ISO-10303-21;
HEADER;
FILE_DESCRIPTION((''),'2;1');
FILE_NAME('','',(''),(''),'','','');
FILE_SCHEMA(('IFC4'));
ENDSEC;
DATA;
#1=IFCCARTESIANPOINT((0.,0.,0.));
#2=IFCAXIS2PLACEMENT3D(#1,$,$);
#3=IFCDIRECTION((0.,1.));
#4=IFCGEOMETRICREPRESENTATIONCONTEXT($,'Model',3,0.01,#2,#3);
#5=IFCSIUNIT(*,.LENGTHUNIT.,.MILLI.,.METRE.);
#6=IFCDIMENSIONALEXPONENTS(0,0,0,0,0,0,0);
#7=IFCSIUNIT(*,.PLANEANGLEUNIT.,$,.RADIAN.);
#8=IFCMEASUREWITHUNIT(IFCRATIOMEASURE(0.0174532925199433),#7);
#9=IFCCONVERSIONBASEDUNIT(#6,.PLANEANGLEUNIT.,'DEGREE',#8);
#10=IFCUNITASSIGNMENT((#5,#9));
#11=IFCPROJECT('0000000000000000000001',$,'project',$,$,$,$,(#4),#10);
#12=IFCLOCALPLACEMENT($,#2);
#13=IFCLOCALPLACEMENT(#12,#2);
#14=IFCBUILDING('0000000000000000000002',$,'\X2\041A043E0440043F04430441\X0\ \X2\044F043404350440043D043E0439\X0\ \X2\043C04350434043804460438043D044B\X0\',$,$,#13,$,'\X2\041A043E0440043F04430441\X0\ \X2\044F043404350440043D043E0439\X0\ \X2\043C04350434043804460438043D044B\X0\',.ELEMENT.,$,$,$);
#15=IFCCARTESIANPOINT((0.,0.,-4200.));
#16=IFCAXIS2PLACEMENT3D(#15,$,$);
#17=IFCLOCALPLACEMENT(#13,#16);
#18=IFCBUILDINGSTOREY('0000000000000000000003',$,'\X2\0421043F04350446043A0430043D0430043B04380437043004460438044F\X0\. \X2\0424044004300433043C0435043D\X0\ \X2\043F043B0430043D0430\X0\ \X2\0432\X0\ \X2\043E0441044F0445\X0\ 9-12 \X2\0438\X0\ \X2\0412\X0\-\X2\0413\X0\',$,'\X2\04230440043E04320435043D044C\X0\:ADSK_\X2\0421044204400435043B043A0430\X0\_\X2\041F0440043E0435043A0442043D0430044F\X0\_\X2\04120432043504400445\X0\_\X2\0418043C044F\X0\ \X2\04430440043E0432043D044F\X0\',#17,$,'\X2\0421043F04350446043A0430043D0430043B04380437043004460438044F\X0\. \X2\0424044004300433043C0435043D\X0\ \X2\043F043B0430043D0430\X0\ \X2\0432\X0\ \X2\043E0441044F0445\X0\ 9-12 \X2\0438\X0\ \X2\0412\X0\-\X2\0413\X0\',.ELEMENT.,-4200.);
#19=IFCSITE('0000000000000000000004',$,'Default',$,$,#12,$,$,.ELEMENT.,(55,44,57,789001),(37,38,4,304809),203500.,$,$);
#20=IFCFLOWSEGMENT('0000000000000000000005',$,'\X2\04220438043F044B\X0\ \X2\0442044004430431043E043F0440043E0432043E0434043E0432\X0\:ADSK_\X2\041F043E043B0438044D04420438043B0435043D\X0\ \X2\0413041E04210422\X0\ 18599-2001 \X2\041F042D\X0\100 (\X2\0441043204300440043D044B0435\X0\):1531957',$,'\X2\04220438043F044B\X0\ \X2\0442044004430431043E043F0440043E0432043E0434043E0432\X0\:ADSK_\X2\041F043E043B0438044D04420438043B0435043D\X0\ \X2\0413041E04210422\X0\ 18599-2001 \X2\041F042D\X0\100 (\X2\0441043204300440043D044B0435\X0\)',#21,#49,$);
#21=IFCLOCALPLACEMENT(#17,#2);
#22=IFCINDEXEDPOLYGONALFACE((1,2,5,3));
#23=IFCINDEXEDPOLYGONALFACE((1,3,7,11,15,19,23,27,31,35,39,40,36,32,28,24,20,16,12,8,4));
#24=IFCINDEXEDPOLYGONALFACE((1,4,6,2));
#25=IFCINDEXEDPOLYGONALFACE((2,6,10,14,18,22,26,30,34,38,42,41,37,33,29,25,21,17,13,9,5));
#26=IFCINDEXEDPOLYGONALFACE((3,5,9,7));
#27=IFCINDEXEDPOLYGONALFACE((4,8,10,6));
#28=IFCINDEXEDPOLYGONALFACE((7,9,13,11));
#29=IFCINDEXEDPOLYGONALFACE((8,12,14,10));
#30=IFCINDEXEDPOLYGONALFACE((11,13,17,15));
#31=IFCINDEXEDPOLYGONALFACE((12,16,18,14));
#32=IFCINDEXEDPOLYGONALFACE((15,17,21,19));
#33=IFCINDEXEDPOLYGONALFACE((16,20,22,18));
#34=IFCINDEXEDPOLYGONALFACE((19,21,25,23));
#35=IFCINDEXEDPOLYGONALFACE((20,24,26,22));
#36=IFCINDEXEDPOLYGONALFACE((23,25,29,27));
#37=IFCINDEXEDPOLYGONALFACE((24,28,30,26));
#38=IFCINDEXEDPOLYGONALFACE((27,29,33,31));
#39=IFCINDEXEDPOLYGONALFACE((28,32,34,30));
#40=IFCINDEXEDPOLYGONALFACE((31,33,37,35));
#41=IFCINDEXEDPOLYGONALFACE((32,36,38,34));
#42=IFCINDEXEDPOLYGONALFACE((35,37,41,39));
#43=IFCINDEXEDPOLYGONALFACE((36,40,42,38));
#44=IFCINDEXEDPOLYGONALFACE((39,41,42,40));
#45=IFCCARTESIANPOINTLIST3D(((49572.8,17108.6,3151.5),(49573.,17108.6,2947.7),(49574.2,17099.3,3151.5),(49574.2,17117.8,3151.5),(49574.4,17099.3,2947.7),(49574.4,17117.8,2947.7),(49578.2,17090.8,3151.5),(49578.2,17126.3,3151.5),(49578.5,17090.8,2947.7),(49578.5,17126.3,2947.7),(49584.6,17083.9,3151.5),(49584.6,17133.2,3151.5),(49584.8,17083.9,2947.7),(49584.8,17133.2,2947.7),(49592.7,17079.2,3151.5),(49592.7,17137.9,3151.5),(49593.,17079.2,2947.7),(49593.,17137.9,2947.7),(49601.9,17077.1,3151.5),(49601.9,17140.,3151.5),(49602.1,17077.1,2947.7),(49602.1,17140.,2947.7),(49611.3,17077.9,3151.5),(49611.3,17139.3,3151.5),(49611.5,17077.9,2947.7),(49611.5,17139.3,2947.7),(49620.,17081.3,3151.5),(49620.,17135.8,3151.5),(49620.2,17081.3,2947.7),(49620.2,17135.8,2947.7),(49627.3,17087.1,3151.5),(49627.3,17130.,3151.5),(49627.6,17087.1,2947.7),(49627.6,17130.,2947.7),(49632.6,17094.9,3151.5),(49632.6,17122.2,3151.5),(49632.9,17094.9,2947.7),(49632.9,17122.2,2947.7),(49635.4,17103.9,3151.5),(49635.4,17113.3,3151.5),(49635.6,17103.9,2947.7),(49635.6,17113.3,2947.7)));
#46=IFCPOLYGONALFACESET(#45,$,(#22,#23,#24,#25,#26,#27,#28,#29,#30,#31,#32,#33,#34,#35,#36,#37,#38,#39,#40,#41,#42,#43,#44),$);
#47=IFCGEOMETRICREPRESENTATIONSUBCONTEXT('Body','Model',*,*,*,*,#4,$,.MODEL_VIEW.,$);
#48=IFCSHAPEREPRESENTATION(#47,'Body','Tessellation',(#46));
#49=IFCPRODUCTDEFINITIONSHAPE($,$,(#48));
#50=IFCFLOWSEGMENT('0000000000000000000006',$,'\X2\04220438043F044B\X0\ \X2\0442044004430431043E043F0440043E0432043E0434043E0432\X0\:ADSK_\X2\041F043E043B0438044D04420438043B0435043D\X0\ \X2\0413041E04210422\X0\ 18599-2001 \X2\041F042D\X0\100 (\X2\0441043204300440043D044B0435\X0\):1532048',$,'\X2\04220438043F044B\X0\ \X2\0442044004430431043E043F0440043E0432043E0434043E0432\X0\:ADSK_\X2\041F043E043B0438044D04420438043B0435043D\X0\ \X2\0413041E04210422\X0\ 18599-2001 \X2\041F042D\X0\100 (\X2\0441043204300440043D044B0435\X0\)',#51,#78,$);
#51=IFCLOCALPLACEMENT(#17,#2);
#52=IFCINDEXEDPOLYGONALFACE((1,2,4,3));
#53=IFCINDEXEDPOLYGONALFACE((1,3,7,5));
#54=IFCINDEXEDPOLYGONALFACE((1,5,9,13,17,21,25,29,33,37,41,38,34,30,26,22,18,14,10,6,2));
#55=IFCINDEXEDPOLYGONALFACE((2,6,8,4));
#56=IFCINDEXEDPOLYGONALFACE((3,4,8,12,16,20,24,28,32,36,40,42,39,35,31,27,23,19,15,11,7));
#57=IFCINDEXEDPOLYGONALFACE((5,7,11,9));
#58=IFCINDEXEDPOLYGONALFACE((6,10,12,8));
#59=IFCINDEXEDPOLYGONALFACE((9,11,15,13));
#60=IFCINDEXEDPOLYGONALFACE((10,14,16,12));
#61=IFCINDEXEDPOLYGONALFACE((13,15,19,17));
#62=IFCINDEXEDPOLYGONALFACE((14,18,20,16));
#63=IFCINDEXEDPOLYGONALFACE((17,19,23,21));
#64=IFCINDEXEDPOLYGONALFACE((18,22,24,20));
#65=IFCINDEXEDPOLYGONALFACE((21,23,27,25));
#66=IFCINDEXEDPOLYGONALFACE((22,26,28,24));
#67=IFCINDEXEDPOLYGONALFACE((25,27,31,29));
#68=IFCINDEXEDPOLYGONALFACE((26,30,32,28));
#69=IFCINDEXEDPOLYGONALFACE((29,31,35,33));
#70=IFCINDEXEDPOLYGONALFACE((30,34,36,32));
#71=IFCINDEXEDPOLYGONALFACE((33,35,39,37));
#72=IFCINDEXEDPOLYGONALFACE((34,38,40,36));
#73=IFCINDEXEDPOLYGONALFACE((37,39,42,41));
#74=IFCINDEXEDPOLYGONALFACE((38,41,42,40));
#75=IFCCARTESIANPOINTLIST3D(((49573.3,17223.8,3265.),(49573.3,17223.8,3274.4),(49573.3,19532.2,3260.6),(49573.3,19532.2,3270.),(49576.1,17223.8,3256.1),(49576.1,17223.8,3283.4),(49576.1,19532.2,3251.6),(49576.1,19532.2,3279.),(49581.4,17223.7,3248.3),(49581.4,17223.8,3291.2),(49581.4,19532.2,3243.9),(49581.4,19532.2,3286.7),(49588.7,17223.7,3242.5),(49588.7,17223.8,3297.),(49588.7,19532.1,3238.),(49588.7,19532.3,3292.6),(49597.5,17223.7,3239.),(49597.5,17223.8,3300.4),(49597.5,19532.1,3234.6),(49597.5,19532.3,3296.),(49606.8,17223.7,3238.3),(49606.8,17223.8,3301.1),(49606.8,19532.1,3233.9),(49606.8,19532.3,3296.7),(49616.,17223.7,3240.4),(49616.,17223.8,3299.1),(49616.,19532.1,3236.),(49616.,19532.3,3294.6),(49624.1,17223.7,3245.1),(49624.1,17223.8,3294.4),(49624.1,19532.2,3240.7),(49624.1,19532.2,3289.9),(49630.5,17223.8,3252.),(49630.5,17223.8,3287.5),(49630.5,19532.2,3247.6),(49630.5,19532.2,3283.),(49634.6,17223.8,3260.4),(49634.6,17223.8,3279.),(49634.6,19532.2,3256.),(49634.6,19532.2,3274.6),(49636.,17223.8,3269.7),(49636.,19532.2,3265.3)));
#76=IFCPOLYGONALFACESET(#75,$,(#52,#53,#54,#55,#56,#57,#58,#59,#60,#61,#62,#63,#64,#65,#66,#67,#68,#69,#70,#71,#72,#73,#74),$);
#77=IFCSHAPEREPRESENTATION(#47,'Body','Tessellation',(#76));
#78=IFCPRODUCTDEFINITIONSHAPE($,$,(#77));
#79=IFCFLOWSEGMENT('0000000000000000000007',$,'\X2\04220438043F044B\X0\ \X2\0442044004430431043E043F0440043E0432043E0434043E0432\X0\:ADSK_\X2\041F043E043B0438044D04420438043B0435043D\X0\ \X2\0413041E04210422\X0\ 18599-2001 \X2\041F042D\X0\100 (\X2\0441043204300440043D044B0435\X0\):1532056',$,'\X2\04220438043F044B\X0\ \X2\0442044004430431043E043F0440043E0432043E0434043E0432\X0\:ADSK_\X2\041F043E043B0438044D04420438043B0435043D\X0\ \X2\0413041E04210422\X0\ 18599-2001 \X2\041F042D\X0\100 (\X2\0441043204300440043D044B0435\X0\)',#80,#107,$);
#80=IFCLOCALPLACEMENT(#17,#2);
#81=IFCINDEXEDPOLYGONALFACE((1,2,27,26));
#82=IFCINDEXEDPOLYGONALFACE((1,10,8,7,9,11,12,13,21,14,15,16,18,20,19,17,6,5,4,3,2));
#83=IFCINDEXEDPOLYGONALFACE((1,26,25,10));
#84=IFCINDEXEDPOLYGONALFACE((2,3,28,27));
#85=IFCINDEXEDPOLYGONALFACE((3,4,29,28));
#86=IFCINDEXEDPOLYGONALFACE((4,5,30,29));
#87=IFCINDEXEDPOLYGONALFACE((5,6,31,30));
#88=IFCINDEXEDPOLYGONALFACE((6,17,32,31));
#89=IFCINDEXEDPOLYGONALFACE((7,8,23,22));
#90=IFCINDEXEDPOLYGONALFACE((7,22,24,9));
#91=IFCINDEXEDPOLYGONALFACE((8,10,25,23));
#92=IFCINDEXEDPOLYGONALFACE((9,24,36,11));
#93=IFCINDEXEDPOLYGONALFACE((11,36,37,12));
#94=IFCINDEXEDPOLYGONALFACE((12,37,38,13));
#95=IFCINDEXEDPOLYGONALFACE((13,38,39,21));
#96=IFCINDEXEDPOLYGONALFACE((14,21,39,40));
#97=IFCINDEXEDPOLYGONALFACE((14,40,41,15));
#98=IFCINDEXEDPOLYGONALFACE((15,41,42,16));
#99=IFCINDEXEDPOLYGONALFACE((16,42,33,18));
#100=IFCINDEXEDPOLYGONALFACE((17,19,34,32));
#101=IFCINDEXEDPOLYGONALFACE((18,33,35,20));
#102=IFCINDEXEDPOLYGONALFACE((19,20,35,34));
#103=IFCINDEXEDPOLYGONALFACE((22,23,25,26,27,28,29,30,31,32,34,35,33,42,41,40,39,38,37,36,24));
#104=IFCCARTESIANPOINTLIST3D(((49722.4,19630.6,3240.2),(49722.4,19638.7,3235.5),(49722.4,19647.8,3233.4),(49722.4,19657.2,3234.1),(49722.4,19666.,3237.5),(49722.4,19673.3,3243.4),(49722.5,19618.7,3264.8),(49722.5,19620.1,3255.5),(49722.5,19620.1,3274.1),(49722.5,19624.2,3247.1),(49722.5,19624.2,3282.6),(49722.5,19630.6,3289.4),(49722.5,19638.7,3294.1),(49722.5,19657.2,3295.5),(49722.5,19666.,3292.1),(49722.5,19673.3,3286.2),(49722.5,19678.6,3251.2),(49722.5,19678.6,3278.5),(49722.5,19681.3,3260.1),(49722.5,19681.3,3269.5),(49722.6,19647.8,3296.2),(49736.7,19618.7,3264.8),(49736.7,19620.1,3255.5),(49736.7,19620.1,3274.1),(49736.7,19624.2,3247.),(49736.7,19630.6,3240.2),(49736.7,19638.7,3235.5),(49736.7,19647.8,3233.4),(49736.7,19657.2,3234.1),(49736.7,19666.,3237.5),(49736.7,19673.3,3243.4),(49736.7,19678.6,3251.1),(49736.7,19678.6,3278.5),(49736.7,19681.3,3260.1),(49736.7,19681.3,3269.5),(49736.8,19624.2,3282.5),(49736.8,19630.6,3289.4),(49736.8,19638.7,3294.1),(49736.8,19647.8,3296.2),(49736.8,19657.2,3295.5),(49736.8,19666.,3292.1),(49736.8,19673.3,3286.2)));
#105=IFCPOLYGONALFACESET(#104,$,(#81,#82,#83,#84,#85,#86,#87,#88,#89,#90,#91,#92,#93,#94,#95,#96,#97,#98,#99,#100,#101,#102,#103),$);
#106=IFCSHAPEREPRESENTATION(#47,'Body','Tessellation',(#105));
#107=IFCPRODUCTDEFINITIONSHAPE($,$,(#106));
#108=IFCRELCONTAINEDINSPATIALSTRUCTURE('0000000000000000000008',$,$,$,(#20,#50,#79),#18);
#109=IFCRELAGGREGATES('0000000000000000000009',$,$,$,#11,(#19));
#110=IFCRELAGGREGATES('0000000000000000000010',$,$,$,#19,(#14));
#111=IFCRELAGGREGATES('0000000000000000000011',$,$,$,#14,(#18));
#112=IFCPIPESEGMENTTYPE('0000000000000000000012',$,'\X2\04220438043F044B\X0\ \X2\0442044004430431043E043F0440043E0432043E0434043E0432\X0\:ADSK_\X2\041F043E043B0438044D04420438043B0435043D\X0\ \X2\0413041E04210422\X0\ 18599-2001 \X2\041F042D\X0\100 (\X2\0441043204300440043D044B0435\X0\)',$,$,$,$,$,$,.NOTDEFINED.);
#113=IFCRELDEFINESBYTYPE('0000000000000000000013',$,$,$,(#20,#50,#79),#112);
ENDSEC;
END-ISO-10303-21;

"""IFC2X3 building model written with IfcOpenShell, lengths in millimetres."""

from ifc_helpers import new_model, entity, si_unit, converted_unit, direction, frame, frame_2d, origin, origin_2d_with_axis, place, context, subcontext, project, spatial, circle, extrude, type_object, element, save


model = new_model("IFC2X3")

# Units and contexts
model_context = context("Model", 3, precision=0.01, world=origin(), true_north=direction((0.0, 1.0)))
body_context = subcontext(model_context, "Body", "Model", "MODEL_VIEW")
ifc_project = project(units=[si_unit("LENGTHUNIT", "METRE", prefix="MILLI"), converted_unit("PLANEANGLEUNIT", "DEGREE", entity("IfcRatioMeasure", 0.0174532925199433), si_unit("PLANEANGLEUNIT", "RADIAN"), dimensions=[0, 0, 0, 0, 0, 0, 0])], contexts=[model_context])

# Site, building, storey
site_placement = place(None, frame((0.0, 0.0, 0.0)))
site = spatial("IfcSite", under=ifc_project, at=site_placement, Name="Default", CompositionType="ELEMENT", RefLatitude=(55, 44, 57, 789001), RefLongitude=(37, 38, 4, 304809), RefElevation=203500.0)
building_placement = place(site_placement, origin())
building = spatial("IfcBuilding", under=site, at=building_placement, Name="Корпус ядерной медицины", LongName="Корпус ядерной медицины", CompositionType="ELEMENT")
storey_placement = place(building_placement, frame((0.0, 0.0, -4200.0)))
storey = spatial("IfcBuildingStorey", under=building, at=storey_placement, Name="Спецканализация. Фрагмен плана в осях 9-12 и В-Г", ObjectType="Уровень:ADSK_Стрелка_Проектная_Вверх_Имя уровня", LongName="Спецканализация. Фрагмен плана в осях 9-12 и В-Г", CompositionType="ELEMENT", Elevation=-4200.0)

# Flow segments
pipe_segment_type = type_object("IfcPipeSegmentType", Name="Типы трубопроводов:ADSK_Полиэтилен ГОСТ 18599-2001 ПЭ100 (сварные)", PredefinedType="NOTDEFINED")
flow_segment_1_placement = place(storey_placement, frame((49571.2, 17075.5, 2947.7)))
element("IfcFlowSegment", 1, at=flow_segment_1_placement, inside=storey, type_object=pipe_segment_type, Name="Типы трубопроводов:ADSK_Полиэтилен ГОСТ 18599-2001 ПЭ100 (сварные):1531957", ObjectType="Типы трубопроводов:ADSK_Полиэтилен ГОСТ 18599-2001 ПЭ100 (сварные)", context=body_context, shape_type="SweptSolid", body=[
    extrude(circle(Radius=31.5, at=frame_2d((0.0, 0.0), x_axis=(1.0, 0.0))), frame((33.3, 33.1, 0.0), z_axis=(-0.001163, 0.0, 0.999999), x_axis=(-0.999999, 0.0, -0.001163)), (0.0, 0.0, 1.0), 203.8),
])
flow_segment_2_placement = place(storey_placement, frame((49571.4, 17223.7, 3232.2)))
element("IfcFlowSegment", 2, at=flow_segment_2_placement, inside=storey, type_object=pipe_segment_type, Name="Типы трубопроводов:ADSK_Полиэтилен ГОСТ 18599-2001 ПЭ100 (сварные):1532048", ObjectType="Типы трубопроводов:ADSK_Полиэтилен ГОСТ 18599-2001 ПЭ100 (сварные)", context=body_context, shape_type="SweptSolid", body=[
    extrude(circle(Radius=31.5, at=frame_2d((0.0, 0.0), x_axis=(1.0, 0.0))), frame((33.1, 0.1, 37.5), z_axis=(0.0, 0.999998, -0.001921), x_axis=(1.0, 0.0, 0.0)), (0.0, 0.0, 1.0), 2308.4),
])
flow_segment_3_placement = place(storey_placement, frame((49722.4, 19617.1, 3231.7)))
element("IfcFlowSegment", 3, at=flow_segment_3_placement, inside=storey, type_object=pipe_segment_type, Name="Типы трубопроводов:ADSK_Полиэтилен ГОСТ 18599-2001 ПЭ100 (сварные):1532056", ObjectType="Типы трубопроводов:ADSK_Полиэтилен ГОСТ 18599-2001 ПЭ100 (сварные)", context=body_context, shape_type="SweptSolid", body=[
    extrude(circle(Radius=31.5, at=origin_2d_with_axis()), frame((0.1, 33.1, 33.1), z_axis=(0.999998, 0.0, -0.002), x_axis=(0.0, -1.0, 0.0)), (0.0, 0.0, 1.0), 14.2),
])

save(model, "model.ifc")
